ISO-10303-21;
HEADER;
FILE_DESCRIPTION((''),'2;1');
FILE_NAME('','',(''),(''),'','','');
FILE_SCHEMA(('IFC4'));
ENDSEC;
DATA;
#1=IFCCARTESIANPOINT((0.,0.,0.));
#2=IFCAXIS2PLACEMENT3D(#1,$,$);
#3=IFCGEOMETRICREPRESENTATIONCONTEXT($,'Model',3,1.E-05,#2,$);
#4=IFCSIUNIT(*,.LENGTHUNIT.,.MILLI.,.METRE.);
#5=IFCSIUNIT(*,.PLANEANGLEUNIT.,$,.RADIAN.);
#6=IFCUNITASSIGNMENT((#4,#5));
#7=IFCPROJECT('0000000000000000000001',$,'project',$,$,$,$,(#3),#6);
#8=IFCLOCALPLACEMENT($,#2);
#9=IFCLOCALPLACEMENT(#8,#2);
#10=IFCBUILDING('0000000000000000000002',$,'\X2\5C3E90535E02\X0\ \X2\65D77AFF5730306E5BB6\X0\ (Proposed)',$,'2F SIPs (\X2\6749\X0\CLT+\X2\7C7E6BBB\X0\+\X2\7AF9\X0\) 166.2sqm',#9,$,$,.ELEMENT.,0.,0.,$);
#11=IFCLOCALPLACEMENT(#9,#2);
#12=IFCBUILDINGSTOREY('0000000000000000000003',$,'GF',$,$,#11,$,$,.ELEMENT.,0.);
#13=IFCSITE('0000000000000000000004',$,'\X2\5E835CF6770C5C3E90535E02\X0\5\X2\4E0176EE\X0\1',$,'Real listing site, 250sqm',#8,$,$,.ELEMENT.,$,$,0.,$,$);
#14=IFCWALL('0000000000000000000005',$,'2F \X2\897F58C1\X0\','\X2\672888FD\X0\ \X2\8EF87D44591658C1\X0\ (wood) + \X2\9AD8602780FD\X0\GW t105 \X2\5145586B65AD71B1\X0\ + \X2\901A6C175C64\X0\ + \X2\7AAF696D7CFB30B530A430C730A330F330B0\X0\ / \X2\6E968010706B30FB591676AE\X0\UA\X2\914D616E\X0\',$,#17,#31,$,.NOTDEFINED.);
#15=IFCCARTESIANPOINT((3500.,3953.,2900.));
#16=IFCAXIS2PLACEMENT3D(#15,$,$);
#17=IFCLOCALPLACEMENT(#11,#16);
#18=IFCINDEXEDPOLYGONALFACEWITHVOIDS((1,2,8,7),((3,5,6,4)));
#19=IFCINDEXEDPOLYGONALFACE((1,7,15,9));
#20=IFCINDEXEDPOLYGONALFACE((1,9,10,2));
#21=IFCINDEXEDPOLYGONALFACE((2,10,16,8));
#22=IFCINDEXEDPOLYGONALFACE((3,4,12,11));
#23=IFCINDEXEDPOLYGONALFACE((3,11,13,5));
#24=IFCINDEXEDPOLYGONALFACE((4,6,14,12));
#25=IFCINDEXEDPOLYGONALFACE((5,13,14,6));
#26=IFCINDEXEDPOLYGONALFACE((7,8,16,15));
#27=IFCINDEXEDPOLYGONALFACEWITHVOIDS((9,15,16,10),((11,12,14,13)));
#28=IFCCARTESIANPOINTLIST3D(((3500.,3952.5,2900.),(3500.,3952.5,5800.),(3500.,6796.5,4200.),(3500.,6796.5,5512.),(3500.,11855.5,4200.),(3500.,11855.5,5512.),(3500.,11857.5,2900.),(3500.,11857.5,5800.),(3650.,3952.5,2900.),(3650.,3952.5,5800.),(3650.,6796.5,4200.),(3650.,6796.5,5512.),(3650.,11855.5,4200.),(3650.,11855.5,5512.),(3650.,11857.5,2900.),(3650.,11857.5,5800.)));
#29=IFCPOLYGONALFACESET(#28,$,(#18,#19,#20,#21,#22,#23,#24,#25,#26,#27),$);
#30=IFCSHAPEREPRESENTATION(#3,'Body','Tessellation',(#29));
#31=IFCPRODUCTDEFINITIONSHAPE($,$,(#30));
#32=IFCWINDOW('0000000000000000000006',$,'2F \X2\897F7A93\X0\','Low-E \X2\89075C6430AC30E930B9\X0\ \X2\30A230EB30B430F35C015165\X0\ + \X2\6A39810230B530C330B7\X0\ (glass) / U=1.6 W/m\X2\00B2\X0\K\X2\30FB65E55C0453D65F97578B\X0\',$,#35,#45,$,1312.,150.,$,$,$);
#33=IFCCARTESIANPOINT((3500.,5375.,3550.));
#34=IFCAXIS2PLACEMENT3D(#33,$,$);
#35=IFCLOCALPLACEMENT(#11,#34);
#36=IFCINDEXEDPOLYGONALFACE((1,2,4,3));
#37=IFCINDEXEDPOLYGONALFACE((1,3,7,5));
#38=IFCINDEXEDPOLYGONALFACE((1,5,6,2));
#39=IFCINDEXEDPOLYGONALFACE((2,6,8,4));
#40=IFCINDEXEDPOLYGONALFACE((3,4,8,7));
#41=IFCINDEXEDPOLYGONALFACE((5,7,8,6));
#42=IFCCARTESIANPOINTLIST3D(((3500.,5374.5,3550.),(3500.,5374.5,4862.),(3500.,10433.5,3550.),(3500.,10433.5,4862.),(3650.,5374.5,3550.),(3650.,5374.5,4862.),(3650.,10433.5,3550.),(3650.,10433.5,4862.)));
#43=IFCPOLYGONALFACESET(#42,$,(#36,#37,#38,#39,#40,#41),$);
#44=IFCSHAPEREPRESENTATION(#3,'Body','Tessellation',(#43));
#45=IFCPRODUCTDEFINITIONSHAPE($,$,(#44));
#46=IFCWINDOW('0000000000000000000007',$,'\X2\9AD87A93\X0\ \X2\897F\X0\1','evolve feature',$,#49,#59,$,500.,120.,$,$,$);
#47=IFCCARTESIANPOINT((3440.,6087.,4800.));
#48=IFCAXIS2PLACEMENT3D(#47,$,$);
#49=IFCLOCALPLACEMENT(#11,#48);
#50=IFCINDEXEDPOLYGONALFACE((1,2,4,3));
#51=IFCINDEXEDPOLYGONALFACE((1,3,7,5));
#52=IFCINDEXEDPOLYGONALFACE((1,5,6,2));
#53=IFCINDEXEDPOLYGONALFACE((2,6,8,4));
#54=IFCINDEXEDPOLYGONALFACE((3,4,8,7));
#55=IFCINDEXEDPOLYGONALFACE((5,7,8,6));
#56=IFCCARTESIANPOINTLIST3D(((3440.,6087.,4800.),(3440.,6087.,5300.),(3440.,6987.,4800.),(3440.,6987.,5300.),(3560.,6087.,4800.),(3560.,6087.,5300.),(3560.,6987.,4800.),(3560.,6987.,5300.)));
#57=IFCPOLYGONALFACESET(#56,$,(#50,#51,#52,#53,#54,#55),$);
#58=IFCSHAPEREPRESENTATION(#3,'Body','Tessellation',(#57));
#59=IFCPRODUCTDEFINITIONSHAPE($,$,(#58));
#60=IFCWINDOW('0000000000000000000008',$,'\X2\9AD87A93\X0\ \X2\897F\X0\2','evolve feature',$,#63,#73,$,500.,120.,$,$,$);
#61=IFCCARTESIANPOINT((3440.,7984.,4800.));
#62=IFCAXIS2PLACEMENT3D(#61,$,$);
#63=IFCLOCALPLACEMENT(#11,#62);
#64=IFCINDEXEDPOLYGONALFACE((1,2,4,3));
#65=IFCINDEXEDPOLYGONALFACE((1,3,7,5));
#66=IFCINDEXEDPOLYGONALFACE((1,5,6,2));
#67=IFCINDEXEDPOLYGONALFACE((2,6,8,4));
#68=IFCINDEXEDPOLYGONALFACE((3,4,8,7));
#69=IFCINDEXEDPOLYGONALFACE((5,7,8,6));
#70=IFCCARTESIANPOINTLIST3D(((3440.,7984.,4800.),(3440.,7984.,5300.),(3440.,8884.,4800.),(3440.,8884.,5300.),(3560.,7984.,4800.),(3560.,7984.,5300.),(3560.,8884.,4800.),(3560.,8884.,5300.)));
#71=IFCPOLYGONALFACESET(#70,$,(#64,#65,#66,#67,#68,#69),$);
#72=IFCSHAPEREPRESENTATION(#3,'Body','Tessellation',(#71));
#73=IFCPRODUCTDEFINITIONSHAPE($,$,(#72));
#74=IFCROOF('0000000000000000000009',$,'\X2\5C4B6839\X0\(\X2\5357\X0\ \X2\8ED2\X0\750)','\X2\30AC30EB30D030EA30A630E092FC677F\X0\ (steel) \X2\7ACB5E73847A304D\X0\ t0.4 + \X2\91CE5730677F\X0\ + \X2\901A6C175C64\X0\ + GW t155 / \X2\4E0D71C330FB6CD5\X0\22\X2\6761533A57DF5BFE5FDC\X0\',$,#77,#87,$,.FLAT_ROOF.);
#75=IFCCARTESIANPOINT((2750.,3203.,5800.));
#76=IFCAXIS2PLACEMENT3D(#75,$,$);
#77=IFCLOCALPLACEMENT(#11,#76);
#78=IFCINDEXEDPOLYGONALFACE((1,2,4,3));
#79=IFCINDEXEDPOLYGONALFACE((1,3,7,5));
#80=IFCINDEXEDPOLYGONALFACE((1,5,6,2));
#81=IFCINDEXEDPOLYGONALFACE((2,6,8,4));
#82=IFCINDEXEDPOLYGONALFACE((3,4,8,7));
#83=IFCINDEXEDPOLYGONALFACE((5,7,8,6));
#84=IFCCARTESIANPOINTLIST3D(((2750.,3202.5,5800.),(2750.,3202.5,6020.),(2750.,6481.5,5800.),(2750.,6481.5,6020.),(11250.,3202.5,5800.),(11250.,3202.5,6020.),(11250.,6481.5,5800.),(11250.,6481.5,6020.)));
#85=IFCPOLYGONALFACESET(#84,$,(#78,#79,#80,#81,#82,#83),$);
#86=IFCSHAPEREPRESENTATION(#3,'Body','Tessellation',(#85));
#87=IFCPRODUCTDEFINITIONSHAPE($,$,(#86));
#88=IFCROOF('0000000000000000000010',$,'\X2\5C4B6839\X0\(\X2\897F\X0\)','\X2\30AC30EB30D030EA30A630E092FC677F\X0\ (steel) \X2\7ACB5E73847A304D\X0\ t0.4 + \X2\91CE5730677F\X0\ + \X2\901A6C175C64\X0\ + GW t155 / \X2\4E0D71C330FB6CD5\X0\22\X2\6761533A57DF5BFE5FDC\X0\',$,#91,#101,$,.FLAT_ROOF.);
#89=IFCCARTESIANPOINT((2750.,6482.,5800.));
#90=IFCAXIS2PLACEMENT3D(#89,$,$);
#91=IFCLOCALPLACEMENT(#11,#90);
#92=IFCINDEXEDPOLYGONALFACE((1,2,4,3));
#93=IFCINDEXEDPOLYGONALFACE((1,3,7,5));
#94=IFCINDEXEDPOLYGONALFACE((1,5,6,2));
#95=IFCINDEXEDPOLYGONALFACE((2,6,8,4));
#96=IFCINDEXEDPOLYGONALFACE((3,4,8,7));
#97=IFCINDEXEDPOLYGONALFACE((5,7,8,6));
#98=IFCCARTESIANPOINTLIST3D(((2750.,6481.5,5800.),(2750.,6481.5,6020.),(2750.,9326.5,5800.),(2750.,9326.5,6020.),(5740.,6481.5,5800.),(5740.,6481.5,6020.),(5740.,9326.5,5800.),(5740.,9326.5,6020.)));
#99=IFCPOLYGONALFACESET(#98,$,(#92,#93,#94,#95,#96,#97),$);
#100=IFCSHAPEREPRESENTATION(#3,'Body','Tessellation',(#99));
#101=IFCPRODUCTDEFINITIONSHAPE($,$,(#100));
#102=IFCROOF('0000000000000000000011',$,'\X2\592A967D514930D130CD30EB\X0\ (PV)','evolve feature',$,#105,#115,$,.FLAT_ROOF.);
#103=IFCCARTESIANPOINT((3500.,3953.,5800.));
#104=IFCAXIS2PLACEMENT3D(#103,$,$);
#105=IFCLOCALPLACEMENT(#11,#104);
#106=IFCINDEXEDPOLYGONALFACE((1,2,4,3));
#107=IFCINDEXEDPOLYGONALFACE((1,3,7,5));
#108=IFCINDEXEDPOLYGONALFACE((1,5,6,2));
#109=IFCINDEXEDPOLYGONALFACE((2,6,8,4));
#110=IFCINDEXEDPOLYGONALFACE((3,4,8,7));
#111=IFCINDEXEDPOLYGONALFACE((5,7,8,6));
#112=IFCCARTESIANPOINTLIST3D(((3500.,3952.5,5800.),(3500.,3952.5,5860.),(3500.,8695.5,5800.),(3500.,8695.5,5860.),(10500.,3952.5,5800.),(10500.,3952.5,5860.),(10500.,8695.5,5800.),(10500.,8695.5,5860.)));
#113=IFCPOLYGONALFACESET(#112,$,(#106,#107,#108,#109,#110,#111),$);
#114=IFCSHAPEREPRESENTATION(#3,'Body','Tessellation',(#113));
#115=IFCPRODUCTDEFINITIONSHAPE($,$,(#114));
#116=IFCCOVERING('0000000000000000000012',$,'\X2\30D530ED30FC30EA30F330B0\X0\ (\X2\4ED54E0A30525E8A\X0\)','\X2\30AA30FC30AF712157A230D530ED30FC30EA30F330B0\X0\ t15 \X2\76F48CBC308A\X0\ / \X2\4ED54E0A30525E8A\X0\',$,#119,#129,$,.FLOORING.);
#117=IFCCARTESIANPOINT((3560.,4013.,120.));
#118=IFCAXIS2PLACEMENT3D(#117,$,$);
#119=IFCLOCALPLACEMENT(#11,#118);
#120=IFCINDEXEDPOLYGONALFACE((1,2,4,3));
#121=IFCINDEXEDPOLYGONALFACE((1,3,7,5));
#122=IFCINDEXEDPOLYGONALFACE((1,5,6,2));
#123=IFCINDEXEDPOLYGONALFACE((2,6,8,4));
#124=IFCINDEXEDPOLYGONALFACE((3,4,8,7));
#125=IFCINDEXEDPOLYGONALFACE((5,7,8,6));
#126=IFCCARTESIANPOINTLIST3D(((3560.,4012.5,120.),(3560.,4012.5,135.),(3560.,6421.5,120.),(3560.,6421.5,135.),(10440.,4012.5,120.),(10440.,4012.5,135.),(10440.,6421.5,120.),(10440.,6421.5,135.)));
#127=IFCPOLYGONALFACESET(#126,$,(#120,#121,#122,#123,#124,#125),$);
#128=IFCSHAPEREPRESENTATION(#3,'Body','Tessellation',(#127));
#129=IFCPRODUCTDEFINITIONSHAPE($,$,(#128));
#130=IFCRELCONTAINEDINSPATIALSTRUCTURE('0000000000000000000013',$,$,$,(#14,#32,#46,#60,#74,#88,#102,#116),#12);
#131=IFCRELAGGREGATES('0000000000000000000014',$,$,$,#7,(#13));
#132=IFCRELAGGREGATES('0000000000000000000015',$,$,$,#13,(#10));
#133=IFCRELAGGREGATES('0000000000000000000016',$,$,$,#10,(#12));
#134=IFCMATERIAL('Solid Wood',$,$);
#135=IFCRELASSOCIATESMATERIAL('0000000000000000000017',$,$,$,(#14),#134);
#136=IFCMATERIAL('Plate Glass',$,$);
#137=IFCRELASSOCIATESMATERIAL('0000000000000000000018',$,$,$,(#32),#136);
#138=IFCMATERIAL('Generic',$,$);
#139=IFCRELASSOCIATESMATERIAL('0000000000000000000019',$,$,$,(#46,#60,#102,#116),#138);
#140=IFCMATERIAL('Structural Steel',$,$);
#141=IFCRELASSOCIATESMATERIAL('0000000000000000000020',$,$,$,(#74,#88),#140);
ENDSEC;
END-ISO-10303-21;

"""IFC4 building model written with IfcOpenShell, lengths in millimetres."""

from ifc_helpers import new_model, si_unit, frame, frame_2d, origin, place, context, project, spatial, rectangle, extrude, material, element, fill, save


model = new_model("IFC4")

# Units and contexts
model_context = context("Model", 3, precision=1e-05, world=origin())
ifc_project = project(units=[si_unit("LENGTHUNIT", "METRE", prefix="MILLI"), si_unit("PLANEANGLEUNIT", "RADIAN")], contexts=[model_context])

# Site, building, storey
site_placement = place(None, origin())
site = spatial("IfcSite", under=ifc_project, at=site_placement, Name="広島県尾道市5丁目1", ObjectType="Real listing site, 250sqm", CompositionType="ELEMENT", RefElevation=0.0)
building_placement = place(site_placement, origin())
building = spatial("IfcBuilding", under=site, at=building_placement, Name="尾道市 旗竿地の家 (Proposed)", ObjectType="2F SIPs (杉CLT+籾殻+竹) 166.2sqm", CompositionType="ELEMENT", ElevationOfRefHeight=0.0, ElevationOfTerrain=0.0)
storey_placement = place(building_placement, origin())
storey = spatial("IfcBuildingStorey", under=building, at=storey_placement, Name="GF", CompositionType="ELEMENT", Elevation=0.0)

# Shared definitions
ifc_material_1 = material(Name="Solid Wood")
ifc_material_2 = material(Name="Generic")

# Shared definitions
ifc_material_3 = material(Name="Plate Glass")

# Wall, openings, windows
wall_1_placement = place(storey_placement, frame((3500.0, 3953.0, 2900.0)))
wall_1 = element("IfcWall", 1, at=wall_1_placement, inside=storey, material=ifc_material_1, Name="2F 西壁", Description="木製 軸組外壁 (wood) + 高性能GW t105 充填断熱 + 通気層 + 窯業系サイディング / 準耐火・外皮UA配慮", PredefinedType="NOTDEFINED", context=model_context, shape_type="SweptSolid", body=[
    extrude(rectangle(XDim=150.0, YDim=7905.0, at=frame_2d((75.0, 3952.0))), frame((3500.0, 3953.0, 2900.0)), (0.0, 0.0, 1.0), 2900.0),
])
opening_1_placement = place(storey_placement, frame((3500.0, 5375.0, 3550.0)))
opening_1 = element("IfcOpeningElement", 2, at=opening_1_placement, cuts=wall_1, PredefinedType="NOTDEFINED", context=model_context, shape_type="SweptSolid", body=[
    extrude(rectangle(XDim=150.0, YDim=5059.0, at=frame_2d((75.0, 2529.0))), frame((3500.0, 5375.0, 3550.0)), (0.0, 0.0, 1.0), 1312.0),
])
opening_2_placement = place(storey_placement, frame((3440.0, 6087.0, 4800.0)))
opening_2 = element("IfcOpeningElement", 3, at=opening_2_placement, cuts=wall_1, PredefinedType="NOTDEFINED", context=model_context, shape_type="SweptSolid", body=[
    extrude(rectangle(XDim=120.0, YDim=900.0, at=frame_2d((60.0, 450.0))), frame((3440.0, 6087.0, 4800.0)), (0.0, 0.0, 1.0), 500.0),
])
opening_3_placement = place(storey_placement, frame((3440.0, 7984.0, 4800.0)))
opening_3 = element("IfcOpeningElement", 4, at=opening_3_placement, cuts=wall_1, PredefinedType="NOTDEFINED", context=model_context, shape_type="SweptSolid", body=[
    extrude(rectangle(XDim=120.0, YDim=900.0, at=frame_2d((60.0, 450.0))), frame((3440.0, 7984.0, 4800.0)), (0.0, 0.0, 1.0), 500.0),
])
window_1_placement = place(storey_placement, frame((3500.0, 5375.0, 3550.0)))
window_1 = element("IfcWindow", 5, at=window_1_placement, inside=storey, material=ifc_material_3, Name="2F 西窓", Description="Low-E 複層ガラス アルゴン封入 + 樹脂サッシ (glass) / U=1.6 W/m²K・日射取得型", OverallHeight=1312.0, OverallWidth=150.0, context=model_context, shape_type="SweptSolid", body=[
    extrude(rectangle(XDim=150.0, YDim=5059.0, at=frame_2d((75.0, 2529.0))), frame((3500.0, 5375.0, 3550.0)), (0.0, 0.0, 1.0), 1312.0),
])
fill(opening_1, window_1)
window_2_placement = place(storey_placement, frame((3440.0, 6087.0, 4800.0)))
window_2 = element("IfcWindow", 6, at=window_2_placement, inside=storey, material=ifc_material_2, Name="高窓 西1", Description="evolve feature", OverallHeight=500.0, OverallWidth=120.0, context=model_context, shape_type="SweptSolid", body=[
    extrude(rectangle(XDim=120.0, YDim=900.0, at=frame_2d((60.0, 450.0))), frame((3440.0, 6087.0, 4800.0)), (0.0, 0.0, 1.0), 500.0),
])
fill(opening_2, window_2)
window_3_placement = place(storey_placement, frame((3440.0, 7984.0, 4800.0)))
window_3 = element("IfcWindow", 7, at=window_3_placement, inside=storey, material=ifc_material_2, Name="高窓 西2", Description="evolve feature", OverallHeight=500.0, OverallWidth=120.0, context=model_context, shape_type="SweptSolid", body=[
    extrude(rectangle(XDim=120.0, YDim=900.0, at=frame_2d((60.0, 450.0))), frame((3440.0, 7984.0, 4800.0)), (0.0, 0.0, 1.0), 500.0),
])
fill(opening_3, window_3)

# Roofs
ifc_material_4 = material(Name="Structural Steel")
roof_1_placement = place(storey_placement, frame((2750.0, 3203.0, 5800.0)))
element("IfcRoof", 8, at=roof_1_placement, inside=storey, material=ifc_material_4, Name="屋根(南 軒750)", Description="ガルバリウム鋼板 (steel) 立平葺き t0.4 + 野地板 + 通気層 + GW t155 / 不燃・法22条区域対応", PredefinedType="FLAT_ROOF", context=model_context, shape_type="SweptSolid", body=[
    extrude(rectangle(XDim=8500.0, YDim=3279.0, at=frame_2d((4250.0, 1639.0))), frame((2750.0, 3203.0, 5800.0)), (0.0, 0.0, 1.0), 220.0),
])
roof_2_placement = place(storey_placement, frame((2750.0, 6482.0, 5800.0)))
element("IfcRoof", 9, at=roof_2_placement, inside=storey, material=ifc_material_4, Name="屋根(西)", Description="ガルバリウム鋼板 (steel) 立平葺き t0.4 + 野地板 + 通気層 + GW t155 / 不燃・法22条区域対応", PredefinedType="FLAT_ROOF", context=model_context, shape_type="SweptSolid", body=[
    extrude(rectangle(XDim=2990.0, YDim=2845.0, at=frame_2d((1495.0, 1422.0))), frame((2750.0, 6482.0, 5800.0)), (0.0, 0.0, 1.0), 220.0),
])
roof_3_placement = place(storey_placement, frame((3500.0, 3953.0, 5800.0)))
element("IfcRoof", 10, at=roof_3_placement, inside=storey, material=ifc_material_2, Name="太陽光パネル (PV)", Description="evolve feature", PredefinedType="FLAT_ROOF", context=model_context, shape_type="SweptSolid", body=[
    extrude(rectangle(XDim=7000.0, YDim=4743.0, at=frame_2d((3500.0, 2371.0))), frame((3500.0, 3953.0, 5800.0)), (0.0, 0.0, 1.0), 60.0),
])

# Covering
covering_placement = place(storey_placement, frame((3560.0, 4013.0, 120.0)))
element("IfcCovering", 11, at=covering_placement, inside=storey, material=ifc_material_2, Name="フローリング (仕上げ床)", Description="オーク無垢フローリング t15 直貼り / 仕上げ床", PredefinedType="FLOORING", context=model_context, shape_type="SweptSolid", body=[
    extrude(rectangle(XDim=6880.0, YDim=2409.0, at=frame_2d((3440.0, 1204.0))), frame((3560.0, 4013.0, 120.0)), (0.0, 0.0, 1.0), 15.0),
])

save(model, "model.ifc")
